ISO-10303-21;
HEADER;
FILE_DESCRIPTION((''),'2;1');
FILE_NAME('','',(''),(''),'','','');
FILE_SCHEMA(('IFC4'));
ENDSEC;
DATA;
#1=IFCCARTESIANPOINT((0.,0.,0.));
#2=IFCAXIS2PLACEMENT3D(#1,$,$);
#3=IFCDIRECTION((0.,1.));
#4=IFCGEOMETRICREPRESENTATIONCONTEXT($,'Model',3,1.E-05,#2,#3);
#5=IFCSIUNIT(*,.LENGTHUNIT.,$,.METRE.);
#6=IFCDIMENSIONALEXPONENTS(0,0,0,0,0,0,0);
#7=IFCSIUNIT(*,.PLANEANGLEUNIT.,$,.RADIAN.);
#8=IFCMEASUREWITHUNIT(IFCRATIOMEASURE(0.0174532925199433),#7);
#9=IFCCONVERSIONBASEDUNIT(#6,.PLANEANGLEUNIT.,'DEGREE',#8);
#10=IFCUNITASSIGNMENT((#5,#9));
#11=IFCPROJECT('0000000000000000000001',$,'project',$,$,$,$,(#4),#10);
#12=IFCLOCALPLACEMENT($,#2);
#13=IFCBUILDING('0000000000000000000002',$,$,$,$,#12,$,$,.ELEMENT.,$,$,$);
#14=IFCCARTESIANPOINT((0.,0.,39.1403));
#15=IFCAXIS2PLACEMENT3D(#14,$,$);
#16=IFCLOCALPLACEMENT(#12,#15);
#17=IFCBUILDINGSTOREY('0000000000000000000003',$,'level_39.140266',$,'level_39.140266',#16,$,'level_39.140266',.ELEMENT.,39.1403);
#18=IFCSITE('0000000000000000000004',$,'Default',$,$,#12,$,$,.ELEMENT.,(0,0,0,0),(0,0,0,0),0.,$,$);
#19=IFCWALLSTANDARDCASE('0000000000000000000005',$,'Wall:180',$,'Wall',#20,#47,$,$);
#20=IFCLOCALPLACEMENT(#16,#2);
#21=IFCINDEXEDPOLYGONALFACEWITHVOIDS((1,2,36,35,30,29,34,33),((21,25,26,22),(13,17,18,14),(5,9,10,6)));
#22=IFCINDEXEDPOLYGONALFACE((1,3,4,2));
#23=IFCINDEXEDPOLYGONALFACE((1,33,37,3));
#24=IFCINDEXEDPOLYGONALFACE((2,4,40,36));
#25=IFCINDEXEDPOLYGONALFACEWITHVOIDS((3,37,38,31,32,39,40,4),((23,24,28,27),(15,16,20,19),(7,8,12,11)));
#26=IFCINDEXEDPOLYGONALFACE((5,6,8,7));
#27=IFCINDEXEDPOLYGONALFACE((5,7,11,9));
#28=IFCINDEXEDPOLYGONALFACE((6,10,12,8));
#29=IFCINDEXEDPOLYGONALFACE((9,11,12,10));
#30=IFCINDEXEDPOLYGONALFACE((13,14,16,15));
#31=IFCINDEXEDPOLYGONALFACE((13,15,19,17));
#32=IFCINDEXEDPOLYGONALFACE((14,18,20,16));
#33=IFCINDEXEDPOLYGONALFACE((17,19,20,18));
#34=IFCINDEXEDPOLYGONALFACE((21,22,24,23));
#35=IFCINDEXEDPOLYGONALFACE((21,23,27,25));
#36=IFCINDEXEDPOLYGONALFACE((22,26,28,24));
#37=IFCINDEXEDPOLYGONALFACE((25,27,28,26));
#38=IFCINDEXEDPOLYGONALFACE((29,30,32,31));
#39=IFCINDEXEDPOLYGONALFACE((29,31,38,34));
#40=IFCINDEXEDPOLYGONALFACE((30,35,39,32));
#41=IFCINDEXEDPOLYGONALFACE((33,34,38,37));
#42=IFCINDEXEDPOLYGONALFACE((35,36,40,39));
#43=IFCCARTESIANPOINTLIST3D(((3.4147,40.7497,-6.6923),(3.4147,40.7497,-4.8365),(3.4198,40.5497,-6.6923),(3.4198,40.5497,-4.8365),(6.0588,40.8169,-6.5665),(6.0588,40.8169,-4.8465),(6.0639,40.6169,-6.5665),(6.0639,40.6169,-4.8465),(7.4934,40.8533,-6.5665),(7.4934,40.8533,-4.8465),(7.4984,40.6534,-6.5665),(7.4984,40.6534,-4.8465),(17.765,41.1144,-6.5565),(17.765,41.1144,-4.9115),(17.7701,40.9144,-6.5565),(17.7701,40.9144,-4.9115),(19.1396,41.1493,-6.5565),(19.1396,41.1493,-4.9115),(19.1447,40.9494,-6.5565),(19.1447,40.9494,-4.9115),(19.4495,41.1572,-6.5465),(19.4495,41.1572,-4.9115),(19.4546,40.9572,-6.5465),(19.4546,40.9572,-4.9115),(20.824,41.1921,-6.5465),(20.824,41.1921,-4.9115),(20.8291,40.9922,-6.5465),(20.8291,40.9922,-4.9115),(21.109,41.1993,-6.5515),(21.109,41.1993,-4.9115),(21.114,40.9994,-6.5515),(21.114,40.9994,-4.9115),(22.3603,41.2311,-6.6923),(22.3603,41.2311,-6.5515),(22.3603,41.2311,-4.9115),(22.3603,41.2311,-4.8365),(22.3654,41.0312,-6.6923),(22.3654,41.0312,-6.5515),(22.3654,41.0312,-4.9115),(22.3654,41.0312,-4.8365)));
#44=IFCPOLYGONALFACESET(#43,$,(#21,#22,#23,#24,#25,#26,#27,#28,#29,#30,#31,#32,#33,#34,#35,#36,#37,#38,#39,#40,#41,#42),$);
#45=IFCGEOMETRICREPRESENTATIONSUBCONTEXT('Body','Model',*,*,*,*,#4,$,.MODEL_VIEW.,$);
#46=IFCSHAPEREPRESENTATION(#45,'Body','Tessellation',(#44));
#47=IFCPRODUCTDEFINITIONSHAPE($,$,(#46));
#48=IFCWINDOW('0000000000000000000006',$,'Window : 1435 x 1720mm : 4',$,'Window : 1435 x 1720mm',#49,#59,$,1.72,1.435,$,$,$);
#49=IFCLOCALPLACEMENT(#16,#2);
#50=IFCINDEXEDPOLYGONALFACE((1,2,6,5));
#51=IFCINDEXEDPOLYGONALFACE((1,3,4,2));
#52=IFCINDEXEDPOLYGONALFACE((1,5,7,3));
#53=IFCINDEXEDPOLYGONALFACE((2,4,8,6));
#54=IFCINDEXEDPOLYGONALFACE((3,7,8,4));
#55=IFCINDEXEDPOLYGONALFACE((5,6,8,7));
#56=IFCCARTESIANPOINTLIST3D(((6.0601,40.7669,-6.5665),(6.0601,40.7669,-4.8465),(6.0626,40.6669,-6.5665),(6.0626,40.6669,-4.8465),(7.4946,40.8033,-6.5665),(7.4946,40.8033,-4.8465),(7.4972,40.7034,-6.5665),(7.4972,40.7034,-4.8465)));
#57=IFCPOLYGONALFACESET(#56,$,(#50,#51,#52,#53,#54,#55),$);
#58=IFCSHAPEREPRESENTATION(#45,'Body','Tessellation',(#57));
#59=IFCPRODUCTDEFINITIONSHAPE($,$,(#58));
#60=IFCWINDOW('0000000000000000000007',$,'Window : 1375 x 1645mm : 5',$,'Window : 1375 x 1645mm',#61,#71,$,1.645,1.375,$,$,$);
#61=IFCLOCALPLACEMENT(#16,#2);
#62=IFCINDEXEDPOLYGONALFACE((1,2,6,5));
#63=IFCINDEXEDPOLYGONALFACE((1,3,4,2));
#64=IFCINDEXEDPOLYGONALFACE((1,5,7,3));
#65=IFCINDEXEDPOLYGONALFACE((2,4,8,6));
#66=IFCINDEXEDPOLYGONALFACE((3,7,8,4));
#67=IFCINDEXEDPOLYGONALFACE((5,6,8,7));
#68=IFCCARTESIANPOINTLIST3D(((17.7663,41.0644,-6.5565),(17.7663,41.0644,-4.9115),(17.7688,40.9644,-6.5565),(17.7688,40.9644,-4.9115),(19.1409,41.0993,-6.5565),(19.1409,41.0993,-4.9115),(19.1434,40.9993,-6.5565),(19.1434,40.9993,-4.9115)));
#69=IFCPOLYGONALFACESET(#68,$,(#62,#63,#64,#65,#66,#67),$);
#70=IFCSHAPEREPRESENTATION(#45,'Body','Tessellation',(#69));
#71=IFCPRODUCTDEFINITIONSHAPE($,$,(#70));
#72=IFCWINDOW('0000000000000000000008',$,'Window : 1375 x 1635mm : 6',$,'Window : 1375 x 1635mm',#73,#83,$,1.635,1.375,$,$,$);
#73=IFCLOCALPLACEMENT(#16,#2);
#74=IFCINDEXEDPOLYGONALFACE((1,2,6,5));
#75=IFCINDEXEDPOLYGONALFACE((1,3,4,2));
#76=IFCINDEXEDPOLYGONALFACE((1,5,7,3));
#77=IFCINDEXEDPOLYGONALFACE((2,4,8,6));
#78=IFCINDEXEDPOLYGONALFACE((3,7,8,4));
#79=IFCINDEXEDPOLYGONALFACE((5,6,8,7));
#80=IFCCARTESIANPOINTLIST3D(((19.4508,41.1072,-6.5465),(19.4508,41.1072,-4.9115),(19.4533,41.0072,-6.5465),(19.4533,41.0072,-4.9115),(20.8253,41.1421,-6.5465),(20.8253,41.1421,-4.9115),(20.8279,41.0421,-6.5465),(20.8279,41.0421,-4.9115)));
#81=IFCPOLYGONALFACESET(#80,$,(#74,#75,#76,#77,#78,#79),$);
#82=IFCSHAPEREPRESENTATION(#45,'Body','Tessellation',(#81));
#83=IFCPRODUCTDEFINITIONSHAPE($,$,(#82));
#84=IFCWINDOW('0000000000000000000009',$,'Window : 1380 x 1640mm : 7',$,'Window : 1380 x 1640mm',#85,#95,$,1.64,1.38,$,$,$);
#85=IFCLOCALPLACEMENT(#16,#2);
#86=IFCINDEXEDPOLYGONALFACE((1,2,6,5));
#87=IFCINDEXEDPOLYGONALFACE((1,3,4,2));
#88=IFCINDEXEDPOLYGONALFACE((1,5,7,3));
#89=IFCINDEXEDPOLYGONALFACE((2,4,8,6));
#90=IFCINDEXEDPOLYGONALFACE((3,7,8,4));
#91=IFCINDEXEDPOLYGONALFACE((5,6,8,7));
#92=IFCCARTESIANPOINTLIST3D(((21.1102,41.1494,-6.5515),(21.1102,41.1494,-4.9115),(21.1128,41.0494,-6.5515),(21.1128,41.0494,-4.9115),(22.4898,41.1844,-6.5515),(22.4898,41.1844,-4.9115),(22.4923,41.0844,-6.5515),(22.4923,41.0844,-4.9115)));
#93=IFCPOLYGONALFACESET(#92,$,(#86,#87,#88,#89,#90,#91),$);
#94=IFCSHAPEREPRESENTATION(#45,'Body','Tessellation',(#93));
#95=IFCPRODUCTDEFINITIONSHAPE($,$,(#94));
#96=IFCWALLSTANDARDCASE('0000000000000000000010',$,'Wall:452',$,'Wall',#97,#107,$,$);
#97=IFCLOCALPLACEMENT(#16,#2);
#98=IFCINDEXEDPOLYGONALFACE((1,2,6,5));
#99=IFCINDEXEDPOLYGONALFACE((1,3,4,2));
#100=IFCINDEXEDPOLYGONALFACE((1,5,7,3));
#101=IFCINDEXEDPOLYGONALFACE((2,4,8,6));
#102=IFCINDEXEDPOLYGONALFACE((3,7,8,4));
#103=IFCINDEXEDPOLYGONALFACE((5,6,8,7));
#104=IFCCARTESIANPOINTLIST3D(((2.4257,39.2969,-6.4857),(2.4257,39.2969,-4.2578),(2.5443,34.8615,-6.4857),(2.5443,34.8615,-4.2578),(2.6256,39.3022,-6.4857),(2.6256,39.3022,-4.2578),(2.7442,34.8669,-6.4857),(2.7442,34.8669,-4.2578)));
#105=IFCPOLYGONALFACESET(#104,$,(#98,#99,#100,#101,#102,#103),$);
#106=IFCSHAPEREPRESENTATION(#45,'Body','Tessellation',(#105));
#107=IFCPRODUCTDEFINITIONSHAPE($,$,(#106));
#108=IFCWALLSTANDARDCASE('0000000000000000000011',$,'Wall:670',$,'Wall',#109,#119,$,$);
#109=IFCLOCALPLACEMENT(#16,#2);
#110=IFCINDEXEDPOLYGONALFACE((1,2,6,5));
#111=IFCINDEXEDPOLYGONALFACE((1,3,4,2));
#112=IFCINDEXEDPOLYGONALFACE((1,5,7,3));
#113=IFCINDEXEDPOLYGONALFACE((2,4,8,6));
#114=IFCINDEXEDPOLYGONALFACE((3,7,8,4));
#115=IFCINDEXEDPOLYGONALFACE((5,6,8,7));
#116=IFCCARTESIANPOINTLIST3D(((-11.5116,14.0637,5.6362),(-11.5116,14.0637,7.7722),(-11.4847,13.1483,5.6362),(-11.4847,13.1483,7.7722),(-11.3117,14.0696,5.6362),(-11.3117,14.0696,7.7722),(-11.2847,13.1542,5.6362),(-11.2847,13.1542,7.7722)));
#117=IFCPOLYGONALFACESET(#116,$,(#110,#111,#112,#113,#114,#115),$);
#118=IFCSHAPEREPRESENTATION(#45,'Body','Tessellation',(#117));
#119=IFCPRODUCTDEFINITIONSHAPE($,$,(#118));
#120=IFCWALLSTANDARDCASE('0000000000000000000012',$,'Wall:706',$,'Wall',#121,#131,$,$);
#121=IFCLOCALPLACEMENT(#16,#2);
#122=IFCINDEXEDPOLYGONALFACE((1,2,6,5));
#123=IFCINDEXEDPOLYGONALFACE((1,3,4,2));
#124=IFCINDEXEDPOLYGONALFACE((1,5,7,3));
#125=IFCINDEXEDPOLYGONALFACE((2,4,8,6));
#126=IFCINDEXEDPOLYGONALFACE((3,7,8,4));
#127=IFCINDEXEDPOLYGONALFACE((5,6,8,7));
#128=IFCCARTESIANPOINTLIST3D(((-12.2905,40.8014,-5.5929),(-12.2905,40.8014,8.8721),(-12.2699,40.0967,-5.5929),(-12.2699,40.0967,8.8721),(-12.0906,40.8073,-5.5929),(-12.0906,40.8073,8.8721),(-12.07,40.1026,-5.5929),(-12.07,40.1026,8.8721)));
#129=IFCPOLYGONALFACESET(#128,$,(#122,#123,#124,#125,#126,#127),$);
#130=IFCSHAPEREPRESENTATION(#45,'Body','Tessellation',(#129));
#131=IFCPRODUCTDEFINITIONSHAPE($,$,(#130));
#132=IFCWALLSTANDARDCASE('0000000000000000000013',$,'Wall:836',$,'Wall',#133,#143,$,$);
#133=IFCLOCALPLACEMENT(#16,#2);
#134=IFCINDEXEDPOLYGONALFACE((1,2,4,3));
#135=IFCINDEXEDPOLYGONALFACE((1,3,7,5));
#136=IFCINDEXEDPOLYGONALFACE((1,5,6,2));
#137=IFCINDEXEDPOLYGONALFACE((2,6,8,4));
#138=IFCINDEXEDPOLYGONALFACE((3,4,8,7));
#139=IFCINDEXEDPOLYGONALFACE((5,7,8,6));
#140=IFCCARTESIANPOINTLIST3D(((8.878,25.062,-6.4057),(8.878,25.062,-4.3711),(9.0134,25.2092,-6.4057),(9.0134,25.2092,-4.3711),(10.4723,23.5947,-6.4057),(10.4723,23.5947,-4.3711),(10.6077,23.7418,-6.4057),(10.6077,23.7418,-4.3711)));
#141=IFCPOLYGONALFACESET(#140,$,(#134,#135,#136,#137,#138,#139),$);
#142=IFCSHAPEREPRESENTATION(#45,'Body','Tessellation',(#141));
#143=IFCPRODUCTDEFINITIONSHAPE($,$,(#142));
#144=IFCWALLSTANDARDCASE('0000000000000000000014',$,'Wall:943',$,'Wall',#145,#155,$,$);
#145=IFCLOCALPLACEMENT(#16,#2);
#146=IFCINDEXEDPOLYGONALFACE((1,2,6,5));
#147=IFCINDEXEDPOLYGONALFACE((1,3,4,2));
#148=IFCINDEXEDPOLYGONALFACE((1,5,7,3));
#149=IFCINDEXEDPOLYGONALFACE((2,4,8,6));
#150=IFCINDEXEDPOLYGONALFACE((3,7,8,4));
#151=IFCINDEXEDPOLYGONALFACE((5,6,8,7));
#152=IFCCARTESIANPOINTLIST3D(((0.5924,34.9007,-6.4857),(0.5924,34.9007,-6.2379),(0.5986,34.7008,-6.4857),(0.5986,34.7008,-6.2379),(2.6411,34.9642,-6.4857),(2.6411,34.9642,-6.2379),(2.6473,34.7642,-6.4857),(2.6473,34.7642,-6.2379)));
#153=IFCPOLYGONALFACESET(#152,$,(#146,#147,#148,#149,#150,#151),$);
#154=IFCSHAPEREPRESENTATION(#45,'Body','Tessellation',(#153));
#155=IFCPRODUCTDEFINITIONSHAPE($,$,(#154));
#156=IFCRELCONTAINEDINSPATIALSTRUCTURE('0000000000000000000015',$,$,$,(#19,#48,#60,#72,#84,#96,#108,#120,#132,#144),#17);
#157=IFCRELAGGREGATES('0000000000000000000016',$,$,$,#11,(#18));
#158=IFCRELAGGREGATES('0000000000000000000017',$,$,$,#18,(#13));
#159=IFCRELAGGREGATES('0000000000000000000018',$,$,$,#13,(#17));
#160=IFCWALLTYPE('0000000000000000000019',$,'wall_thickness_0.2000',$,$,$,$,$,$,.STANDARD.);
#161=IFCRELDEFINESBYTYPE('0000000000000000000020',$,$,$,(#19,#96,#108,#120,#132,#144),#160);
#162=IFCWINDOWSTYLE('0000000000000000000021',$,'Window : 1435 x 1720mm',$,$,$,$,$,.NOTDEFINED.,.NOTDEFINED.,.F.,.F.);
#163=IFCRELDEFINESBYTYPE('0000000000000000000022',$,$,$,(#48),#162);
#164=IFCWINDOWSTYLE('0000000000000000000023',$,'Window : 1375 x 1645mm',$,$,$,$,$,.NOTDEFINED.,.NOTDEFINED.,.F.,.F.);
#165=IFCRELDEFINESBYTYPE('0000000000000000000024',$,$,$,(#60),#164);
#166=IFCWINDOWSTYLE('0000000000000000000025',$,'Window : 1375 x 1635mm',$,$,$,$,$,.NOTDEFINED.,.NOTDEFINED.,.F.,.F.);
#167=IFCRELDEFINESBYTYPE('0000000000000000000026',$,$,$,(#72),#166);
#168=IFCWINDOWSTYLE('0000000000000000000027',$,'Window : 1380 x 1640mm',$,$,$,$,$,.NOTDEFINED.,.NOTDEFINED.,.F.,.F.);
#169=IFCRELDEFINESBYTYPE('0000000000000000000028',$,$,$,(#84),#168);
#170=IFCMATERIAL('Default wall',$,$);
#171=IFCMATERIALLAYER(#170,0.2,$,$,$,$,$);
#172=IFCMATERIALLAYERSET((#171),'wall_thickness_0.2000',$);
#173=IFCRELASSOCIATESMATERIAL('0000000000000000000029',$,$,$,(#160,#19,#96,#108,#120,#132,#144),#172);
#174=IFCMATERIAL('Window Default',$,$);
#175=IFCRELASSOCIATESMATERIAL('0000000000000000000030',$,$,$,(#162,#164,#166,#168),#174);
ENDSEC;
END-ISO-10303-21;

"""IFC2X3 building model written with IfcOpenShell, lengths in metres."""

from ifc_helpers import new_model, entity, si_unit, converted_unit, direction, frame, frame_2d, origin, origin_2d_with_axis, place, context, subcontext, project, spatial, polyline, rectangle, outline, extrude, source, transform, mapped, material, layer, layer_set, layer_usage, type_object, type_shapes, element, fill, save


model = new_model("IFC2X3")

# Units and contexts
model_context = context("Model", 3, precision=1e-05, world=origin(), true_north=direction((0.0, 1.0)))
body_context = subcontext(model_context, "Body", "Model", "MODEL_VIEW")
ifc_project = project(units=[si_unit("LENGTHUNIT", "METRE"), converted_unit("PLANEANGLEUNIT", "DEGREE", entity("IfcRatioMeasure", 0.0174532925199433), si_unit("PLANEANGLEUNIT", "RADIAN"), dimensions=[0, 0, 0, 0, 0, 0, 0])], contexts=[model_context])

# Site, building, storey
placement_1 = place(None, origin())
site = spatial("IfcSite", under=ifc_project, at=placement_1, Name="Default", CompositionType="ELEMENT", RefLatitude=(0, 0, 0, 0), RefLongitude=(0, 0, 0, 0), RefElevation=0.0)
building = spatial("IfcBuilding", under=site, at=placement_1, CompositionType="ELEMENT")
storey_placement = place(placement_1, frame((0.0, 0.0, 39.1403)))
storey = spatial("IfcBuildingStorey", under=building, at=storey_placement, Name="level_39.140266", ObjectType="level_39.140266", LongName="level_39.140266", CompositionType="ELEMENT", Elevation=39.1403)

# Wall, openings, windows
ifc_material_1 = material(Name="Default wall")
ifc_layer = layer(ifc_material_1, 0.2)
ifc_layer_set = layer_set([ifc_layer], Name="wall_thickness_0.2000")
ifc_layer_usage = layer_usage(ifc_layer_set, "AXIS2", "POSITIVE", -0.1)
wall_type = type_object("IfcWallType", Name="wall_thickness_0.2000", PredefinedType="STANDARD", material=ifc_layer_set)
placement_2 = place(placement_1, frame((0.0, 0.0, 32.448)))
wall_1_placement = place(placement_2, frame((3.4172, 40.6497, 0.0), z_axis=(0.0, 0.0, 1.0), x_axis=(0.999677, 0.025406, 0.0)))
wall_1 = element("IfcWallStandardCase", 1, at=wall_1_placement, inside=storey, type_object=wall_type, material=ifc_layer_usage, Name="Wall:180", ObjectType="Wall", context=body_context, shape_type="SweptSolid", body=[
    extrude(outline(polyline([(18.9517, -0.1), (18.9517, 0.1), (0.0, 0.1), (0.0, -0.1), (18.9517, -0.1)])), origin(), (0.0, 0.0, 1.0), 1.8558),
])
opening_1_placement = place(wall_1_placement, frame((2.645, -0.1, 0.1258)))
opening_1 = element("IfcOpeningElement", 2, at=opening_1_placement, cuts=wall_1, ObjectType="Opening", context=body_context, shape_type="SweptSolid", body=[
    extrude(rectangle(XDim=1.435, YDim=1.72, at=frame_2d((0.86, 0.7175), x_axis=(0.0, 1.0))), frame((0.0, 0.0, 0.0), z_axis=(0.0, 1.0, 0.0), x_axis=(0.0, 0.0, 1.0)), (0.0, 0.0, 1.0), 0.2),
])
opening_2_placement = place(wall_1_placement, frame((14.355, -0.1, 0.1358)))
opening_2 = element("IfcOpeningElement", 3, at=opening_2_placement, cuts=wall_1, ObjectType="Opening", context=body_context, shape_type="SweptSolid", body=[
    extrude(rectangle(XDim=1.375, YDim=1.645, at=frame_2d((0.8225, 0.6875), x_axis=(0.0, 1.0))), frame((0.0, 0.0, 0.0), z_axis=(0.0, 1.0, 0.0), x_axis=(0.0, 0.0, 1.0)), (0.0, 0.0, 1.0), 0.2),
])
opening_3_placement = place(wall_1_placement, frame((16.04, -0.1, 0.1458)))
opening_3 = element("IfcOpeningElement", 4, at=opening_3_placement, cuts=wall_1, ObjectType="Opening", context=body_context, shape_type="SweptSolid", body=[
    extrude(rectangle(XDim=1.375, YDim=1.635, at=frame_2d((0.8175, 0.6875), x_axis=(0.0, 1.0))), frame((0.0, 0.0, 0.0), z_axis=(0.0, 1.0, 0.0), x_axis=(0.0, 0.0, 1.0)), (0.0, 0.0, 1.0), 0.2),
])
opening_4_placement = place(wall_1_placement, frame((17.7, -0.1, 0.1408)))
opening_4 = element("IfcOpeningElement", 5, at=opening_4_placement, cuts=wall_1, ObjectType="Opening", context=body_context, shape_type="SweptSolid", body=[
    extrude(rectangle(XDim=1.38, YDim=1.64, at=frame_2d((0.82, 0.69), x_axis=(0.0, 1.0))), frame((0.0, 0.0, 0.0), z_axis=(0.0, 1.0, 0.0), x_axis=(0.0, 0.0, 1.0)), (0.0, 0.0, 1.0), 0.2),
])
ifc_material_2 = material(Name="Window Default")
window_style_1 = type_object("IfcWindowStyle", Name="Window : 1435 x 1720mm", ConstructionType="NOTDEFINED", OperationType="NOTDEFINED", ParameterTakesPrecedence=False, Sizeable=False, material=ifc_material_2)
shared_shape_1 = source(origin(), body_context, "Body", "SweptSolid", [
    extrude(rectangle(XDim=0.1, YDim=1.435, at=origin_2d_with_axis()), frame((0.7175, 0.1, 0.0), z_axis=(0.0, 0.0, 1.0), x_axis=(0.0, 1.0, 0.0)), (0.0, 0.0, 1.0), 1.72),
])
type_shapes(window_style_1, [shared_shape_1])
window_1_placement = place(opening_1_placement, origin())
window_1 = element("IfcWindow", 6, at=window_1_placement, inside=storey, type_object=window_style_1, Name="Window : 1435 x 1720mm : 4", ObjectType="Window : 1435 x 1720mm", OverallHeight=1.72, OverallWidth=1.435, context=body_context, shape_type="MappedRepresentation", body=[
    mapped(shared_shape_1, transform((0.0, 0.0, 0.0), scale=1.0)),
])
fill(opening_1, window_1)
window_style_2 = type_object("IfcWindowStyle", Name="Window : 1375 x 1645mm", ConstructionType="NOTDEFINED", OperationType="NOTDEFINED", ParameterTakesPrecedence=False, Sizeable=False, material=ifc_material_2)
shared_shape_2 = source(origin(), body_context, "Body", "SweptSolid", [
    extrude(rectangle(XDim=0.1, YDim=1.375, at=origin_2d_with_axis()), frame((0.6875, 0.1, 0.0), z_axis=(0.0, 0.0, 1.0), x_axis=(0.0, 1.0, 0.0)), (0.0, 0.0, 1.0), 1.645),
])
type_shapes(window_style_2, [shared_shape_2])
window_2_placement = place(opening_2_placement, origin())
window_2 = element("IfcWindow", 7, at=window_2_placement, inside=storey, type_object=window_style_2, Name="Window : 1375 x 1645mm : 5", ObjectType="Window : 1375 x 1645mm", OverallHeight=1.645, OverallWidth=1.375, context=body_context, shape_type="MappedRepresentation", body=[
    mapped(shared_shape_2, transform((0.0, 0.0, 0.0), scale=1.0)),
])
fill(opening_2, window_2)
window_style_3 = type_object("IfcWindowStyle", Name="Window : 1375 x 1635mm", ConstructionType="NOTDEFINED", OperationType="NOTDEFINED", ParameterTakesPrecedence=False, Sizeable=False, material=ifc_material_2)
shared_shape_3 = source(origin(), body_context, "Body", "SweptSolid", [
    extrude(rectangle(XDim=0.1, YDim=1.375, at=origin_2d_with_axis()), frame((0.6875, 0.1, 0.0), z_axis=(0.0, 0.0, 1.0), x_axis=(0.0, 1.0, 0.0)), (0.0, 0.0, 1.0), 1.635),
])
type_shapes(window_style_3, [shared_shape_3])
window_3_placement = place(opening_3_placement, origin())
window_3 = element("IfcWindow", 8, at=window_3_placement, inside=storey, type_object=window_style_3, Name="Window : 1375 x 1635mm : 6", ObjectType="Window : 1375 x 1635mm", OverallHeight=1.635, OverallWidth=1.375, context=body_context, shape_type="MappedRepresentation", body=[
    mapped(shared_shape_3, transform((0.0, 0.0, 0.0), scale=1.0)),
])
fill(opening_3, window_3)
window_style_4 = type_object("IfcWindowStyle", Name="Window : 1380 x 1640mm", ConstructionType="NOTDEFINED", OperationType="NOTDEFINED", ParameterTakesPrecedence=False, Sizeable=False, material=ifc_material_2)
shared_shape_4 = source(origin(), body_context, "Body", "SweptSolid", [
    extrude(rectangle(XDim=0.1, YDim=1.38, at=origin_2d_with_axis()), frame((0.69, 0.1, 0.0), z_axis=(0.0, 0.0, 1.0), x_axis=(0.0, 1.0, 0.0)), (0.0, 0.0, 1.0), 1.64),
])
type_shapes(window_style_4, [shared_shape_4])
window_4_placement = place(opening_4_placement, origin())
window_4 = element("IfcWindow", 9, at=window_4_placement, inside=storey, type_object=window_style_4, Name="Window : 1380 x 1640mm : 7", ObjectType="Window : 1380 x 1640mm", OverallHeight=1.64, OverallWidth=1.38, context=body_context, shape_type="MappedRepresentation", body=[
    mapped(shared_shape_4, transform((0.0, 0.0, 0.0), scale=1.0)),
])
fill(opening_4, window_4)

# Walls
placement_3 = place(placement_1, frame((0.0, 0.0, 32.6546)))
wall_2_placement = place(placement_3, frame((2.5257, 39.2995, 0.0), z_axis=(0.0, 0.0, 1.0), x_axis=(0.026719, -0.999643, 0.0)))
element("IfcWallStandardCase", 10, at=wall_2_placement, inside=storey, type_object=wall_type, material=ifc_layer_usage, Name="Wall:452", ObjectType="Wall", context=body_context, shape_type="SweptSolid", body=[
    extrude(outline(polyline([(4.4369, -0.1), (4.4369, 0.1), (0.0, 0.1), (0.0, -0.1), (4.4369, -0.1)])), origin(), (0.0, 0.0, 1.0), 2.2279),
])
placement_4 = place(placement_1, frame((0.0, 0.0, 44.7765)))
wall_3_placement = place(placement_4, frame((-11.3847, 13.1512, 0.0), z_axis=(0.0, 0.0, 1.0), x_axis=(-0.029383, 0.999568, 0.0)))
element("IfcWallStandardCase", 11, at=wall_3_placement, inside=storey, type_object=wall_type, material=ifc_layer_usage, Name="Wall:670", ObjectType="Wall", context=body_context, shape_type="SweptSolid", body=[
    extrude(outline(polyline([(0.9159, -0.1), (0.9159, 0.1), (0.0, 0.1), (0.0, -0.1), (0.9159, -0.1)])), origin(), (0.0, 0.0, 1.0), 2.136),
])
placement_5 = place(placement_1, frame((0.0, 0.0, 33.5474)))
wall_4_placement = place(placement_5, frame((-12.1699, 40.0996, 0.0), z_axis=(0.0, 0.0, 1.0), x_axis=(-0.029268, 0.999572, 0.0)))
element("IfcWallStandardCase", 12, at=wall_4_placement, inside=storey, type_object=wall_type, material=ifc_layer_usage, Name="Wall:706", ObjectType="Wall", context=body_context, shape_type="SweptSolid", body=[
    extrude(outline(polyline([(0.705, -0.1), (0.705, 0.1), (0.0, 0.1), (0.0, -0.1), (0.705, -0.1)])), origin(), (0.0, 0.0, 1.0), 14.465),
])

# Walls
placement_6 = place(placement_1, frame((0.0, 0.0, 32.7346)))
wall_5_placement = place(placement_6, frame((10.54, 23.6682, 0.0), z_axis=(0.0, 0.0, 1.0), x_axis=(-0.735805, 0.677193, 0.0)))
element("IfcWallStandardCase", 13, at=wall_5_placement, inside=storey, type_object=wall_type, material=ifc_layer_usage, Name="Wall:836", ObjectType="Wall", context=body_context, shape_type="SweptSolid", body=[
    extrude(outline(polyline([(2.1668, -0.1), (2.1668, 0.1), (0.0, 0.1), (0.0, -0.1), (2.1668, -0.1)])), origin(), (0.0, 0.0, 1.0), 2.0347),
])
placement_7 = place(placement_1, frame((0.0, 0.0, 32.6546)))
wall_6_placement = place(placement_7, frame((0.5955, 34.8007, 0.0), z_axis=(0.0, 0.0, 1.0), x_axis=(0.99952, 0.030977, 0.0)))
element("IfcWallStandardCase", 14, at=wall_6_placement, inside=storey, type_object=wall_type, material=ifc_layer_usage, Name="Wall:943", ObjectType="Wall", context=body_context, shape_type="SweptSolid", body=[
    extrude(outline(polyline([(2.0498, -0.1), (2.0498, 0.1), (0.0, 0.1), (0.0, -0.1), (2.0498, -0.1)])), origin(), (0.0, 0.0, 1.0), 0.2478),
])

save(model, "model.ifc")
